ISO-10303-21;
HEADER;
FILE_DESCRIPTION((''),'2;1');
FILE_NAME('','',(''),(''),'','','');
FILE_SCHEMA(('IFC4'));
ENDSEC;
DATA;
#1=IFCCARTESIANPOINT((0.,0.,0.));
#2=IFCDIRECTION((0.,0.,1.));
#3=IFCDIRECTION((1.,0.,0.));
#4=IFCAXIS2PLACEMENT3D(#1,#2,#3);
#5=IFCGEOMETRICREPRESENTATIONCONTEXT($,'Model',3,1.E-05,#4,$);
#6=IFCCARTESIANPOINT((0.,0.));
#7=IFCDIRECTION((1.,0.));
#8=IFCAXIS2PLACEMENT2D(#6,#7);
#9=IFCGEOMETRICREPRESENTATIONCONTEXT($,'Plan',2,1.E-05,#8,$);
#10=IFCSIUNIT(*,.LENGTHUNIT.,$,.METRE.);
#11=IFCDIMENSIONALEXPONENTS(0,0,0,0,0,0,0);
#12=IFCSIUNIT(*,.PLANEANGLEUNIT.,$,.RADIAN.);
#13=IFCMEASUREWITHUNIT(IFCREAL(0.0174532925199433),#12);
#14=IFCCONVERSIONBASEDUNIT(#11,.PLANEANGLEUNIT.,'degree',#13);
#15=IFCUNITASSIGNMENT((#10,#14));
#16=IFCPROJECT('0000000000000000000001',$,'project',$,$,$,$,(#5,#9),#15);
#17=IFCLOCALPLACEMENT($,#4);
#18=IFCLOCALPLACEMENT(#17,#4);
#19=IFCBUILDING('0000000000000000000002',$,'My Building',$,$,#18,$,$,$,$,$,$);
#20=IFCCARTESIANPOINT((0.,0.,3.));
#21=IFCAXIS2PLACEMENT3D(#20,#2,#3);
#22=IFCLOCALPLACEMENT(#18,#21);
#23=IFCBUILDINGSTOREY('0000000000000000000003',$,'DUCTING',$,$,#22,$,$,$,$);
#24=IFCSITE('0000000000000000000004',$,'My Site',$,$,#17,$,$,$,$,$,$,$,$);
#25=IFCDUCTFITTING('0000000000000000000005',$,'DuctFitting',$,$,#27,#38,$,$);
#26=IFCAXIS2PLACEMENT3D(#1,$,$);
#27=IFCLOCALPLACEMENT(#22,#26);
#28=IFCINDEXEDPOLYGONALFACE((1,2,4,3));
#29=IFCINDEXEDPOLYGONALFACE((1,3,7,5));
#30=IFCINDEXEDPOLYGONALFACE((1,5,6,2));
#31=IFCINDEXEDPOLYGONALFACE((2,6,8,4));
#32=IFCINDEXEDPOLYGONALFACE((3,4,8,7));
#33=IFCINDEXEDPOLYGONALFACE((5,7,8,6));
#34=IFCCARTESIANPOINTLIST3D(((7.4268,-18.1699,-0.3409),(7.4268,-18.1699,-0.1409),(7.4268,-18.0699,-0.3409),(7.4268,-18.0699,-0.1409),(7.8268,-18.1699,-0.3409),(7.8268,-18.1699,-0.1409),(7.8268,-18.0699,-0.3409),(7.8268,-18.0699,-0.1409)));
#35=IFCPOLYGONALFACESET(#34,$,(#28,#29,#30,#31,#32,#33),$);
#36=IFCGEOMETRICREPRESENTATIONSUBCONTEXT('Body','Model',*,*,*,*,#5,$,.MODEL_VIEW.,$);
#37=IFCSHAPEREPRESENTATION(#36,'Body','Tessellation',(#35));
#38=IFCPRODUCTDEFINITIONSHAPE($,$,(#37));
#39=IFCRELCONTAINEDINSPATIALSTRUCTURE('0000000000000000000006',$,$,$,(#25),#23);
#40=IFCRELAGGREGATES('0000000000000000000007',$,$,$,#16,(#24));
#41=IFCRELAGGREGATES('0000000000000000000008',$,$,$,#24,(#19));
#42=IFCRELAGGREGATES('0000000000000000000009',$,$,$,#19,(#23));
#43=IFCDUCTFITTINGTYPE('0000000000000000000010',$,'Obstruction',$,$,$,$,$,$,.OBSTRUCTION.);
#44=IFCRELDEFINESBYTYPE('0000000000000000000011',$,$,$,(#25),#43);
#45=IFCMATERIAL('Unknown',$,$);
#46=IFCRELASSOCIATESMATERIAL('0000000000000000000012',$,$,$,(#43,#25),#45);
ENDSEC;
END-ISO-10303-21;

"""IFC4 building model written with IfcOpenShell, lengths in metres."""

from ifc_helpers import new_model, entity, si_unit, converted_unit, frame, origin_with_axes, origin_2d_with_axis, place, context, subcontext, project, spatial, rectangle, extrude, material, material_profile, profile_set, profile_usage, type_object, element, save


model = new_model("IFC4")

# Units and contexts
model_context = context("Model", 3, precision=1e-05, world=origin_with_axes())
plan_context = context("Plan", 2, precision=1e-05, world=origin_2d_with_axis())
body_context = subcontext(model_context, "Body", "Model", "MODEL_VIEW")
ifc_project = project(units=[si_unit("LENGTHUNIT", "METRE"), converted_unit("PLANEANGLEUNIT", "degree", entity("IfcReal", 0.0174532925199433), si_unit("PLANEANGLEUNIT", "RADIAN"), dimensions=[0, 0, 0, 0, 0, 0, 0])], contexts=[model_context, plan_context])

# Site, building, storey
site_placement = place(None, origin_with_axes())
site = spatial("IfcSite", under=ifc_project, at=site_placement, Name="My Site")
building_placement = place(site_placement, origin_with_axes())
building = spatial("IfcBuilding", under=site, at=building_placement, Name="My Building")
storey_placement = place(building_placement, frame((0.0, 0.0, 3.0), z_axis=(0.0, 0.0, 1.0), x_axis=(1.0, 0.0, 0.0)))
storey = spatial("IfcBuildingStorey", under=building, at=storey_placement, Name="DUCTING")

# Shared definitions
ifc_material = material(Name="Unknown")

# Duct fitting
ifc_material_profile_1 = material_profile(ifc_material, rectangle(XDim=0.4, YDim=0.2))
ifc_profile_set_1 = profile_set([ifc_material_profile_1])
duct_fitting_type = type_object("IfcDuctFittingType", Name="Obstruction", PredefinedType="OBSTRUCTION", material=ifc_profile_set_1)
ifc_profile_usage_1 = profile_usage(ifc_profile_set_1, cardinal=5)
duct_fitting_1_placement = place(storey_placement, frame((7.6268, -18.0699, -0.2409), z_axis=(0.0, -1.0, 0.0), x_axis=(1.0, 0.0, 0.0)))
element("IfcDuctFitting", 1, at=duct_fitting_1_placement, inside=storey, type_object=duct_fitting_type, material=ifc_profile_usage_1, Name="DuctFitting", context=body_context, shape_type="SweptSolid", body=[
    extrude(rectangle(XDim=0.4, YDim=0.2), origin_with_axes(), (0.0, 0.0, 1.0), 0.1),
])

save(model, "model.ifc")
